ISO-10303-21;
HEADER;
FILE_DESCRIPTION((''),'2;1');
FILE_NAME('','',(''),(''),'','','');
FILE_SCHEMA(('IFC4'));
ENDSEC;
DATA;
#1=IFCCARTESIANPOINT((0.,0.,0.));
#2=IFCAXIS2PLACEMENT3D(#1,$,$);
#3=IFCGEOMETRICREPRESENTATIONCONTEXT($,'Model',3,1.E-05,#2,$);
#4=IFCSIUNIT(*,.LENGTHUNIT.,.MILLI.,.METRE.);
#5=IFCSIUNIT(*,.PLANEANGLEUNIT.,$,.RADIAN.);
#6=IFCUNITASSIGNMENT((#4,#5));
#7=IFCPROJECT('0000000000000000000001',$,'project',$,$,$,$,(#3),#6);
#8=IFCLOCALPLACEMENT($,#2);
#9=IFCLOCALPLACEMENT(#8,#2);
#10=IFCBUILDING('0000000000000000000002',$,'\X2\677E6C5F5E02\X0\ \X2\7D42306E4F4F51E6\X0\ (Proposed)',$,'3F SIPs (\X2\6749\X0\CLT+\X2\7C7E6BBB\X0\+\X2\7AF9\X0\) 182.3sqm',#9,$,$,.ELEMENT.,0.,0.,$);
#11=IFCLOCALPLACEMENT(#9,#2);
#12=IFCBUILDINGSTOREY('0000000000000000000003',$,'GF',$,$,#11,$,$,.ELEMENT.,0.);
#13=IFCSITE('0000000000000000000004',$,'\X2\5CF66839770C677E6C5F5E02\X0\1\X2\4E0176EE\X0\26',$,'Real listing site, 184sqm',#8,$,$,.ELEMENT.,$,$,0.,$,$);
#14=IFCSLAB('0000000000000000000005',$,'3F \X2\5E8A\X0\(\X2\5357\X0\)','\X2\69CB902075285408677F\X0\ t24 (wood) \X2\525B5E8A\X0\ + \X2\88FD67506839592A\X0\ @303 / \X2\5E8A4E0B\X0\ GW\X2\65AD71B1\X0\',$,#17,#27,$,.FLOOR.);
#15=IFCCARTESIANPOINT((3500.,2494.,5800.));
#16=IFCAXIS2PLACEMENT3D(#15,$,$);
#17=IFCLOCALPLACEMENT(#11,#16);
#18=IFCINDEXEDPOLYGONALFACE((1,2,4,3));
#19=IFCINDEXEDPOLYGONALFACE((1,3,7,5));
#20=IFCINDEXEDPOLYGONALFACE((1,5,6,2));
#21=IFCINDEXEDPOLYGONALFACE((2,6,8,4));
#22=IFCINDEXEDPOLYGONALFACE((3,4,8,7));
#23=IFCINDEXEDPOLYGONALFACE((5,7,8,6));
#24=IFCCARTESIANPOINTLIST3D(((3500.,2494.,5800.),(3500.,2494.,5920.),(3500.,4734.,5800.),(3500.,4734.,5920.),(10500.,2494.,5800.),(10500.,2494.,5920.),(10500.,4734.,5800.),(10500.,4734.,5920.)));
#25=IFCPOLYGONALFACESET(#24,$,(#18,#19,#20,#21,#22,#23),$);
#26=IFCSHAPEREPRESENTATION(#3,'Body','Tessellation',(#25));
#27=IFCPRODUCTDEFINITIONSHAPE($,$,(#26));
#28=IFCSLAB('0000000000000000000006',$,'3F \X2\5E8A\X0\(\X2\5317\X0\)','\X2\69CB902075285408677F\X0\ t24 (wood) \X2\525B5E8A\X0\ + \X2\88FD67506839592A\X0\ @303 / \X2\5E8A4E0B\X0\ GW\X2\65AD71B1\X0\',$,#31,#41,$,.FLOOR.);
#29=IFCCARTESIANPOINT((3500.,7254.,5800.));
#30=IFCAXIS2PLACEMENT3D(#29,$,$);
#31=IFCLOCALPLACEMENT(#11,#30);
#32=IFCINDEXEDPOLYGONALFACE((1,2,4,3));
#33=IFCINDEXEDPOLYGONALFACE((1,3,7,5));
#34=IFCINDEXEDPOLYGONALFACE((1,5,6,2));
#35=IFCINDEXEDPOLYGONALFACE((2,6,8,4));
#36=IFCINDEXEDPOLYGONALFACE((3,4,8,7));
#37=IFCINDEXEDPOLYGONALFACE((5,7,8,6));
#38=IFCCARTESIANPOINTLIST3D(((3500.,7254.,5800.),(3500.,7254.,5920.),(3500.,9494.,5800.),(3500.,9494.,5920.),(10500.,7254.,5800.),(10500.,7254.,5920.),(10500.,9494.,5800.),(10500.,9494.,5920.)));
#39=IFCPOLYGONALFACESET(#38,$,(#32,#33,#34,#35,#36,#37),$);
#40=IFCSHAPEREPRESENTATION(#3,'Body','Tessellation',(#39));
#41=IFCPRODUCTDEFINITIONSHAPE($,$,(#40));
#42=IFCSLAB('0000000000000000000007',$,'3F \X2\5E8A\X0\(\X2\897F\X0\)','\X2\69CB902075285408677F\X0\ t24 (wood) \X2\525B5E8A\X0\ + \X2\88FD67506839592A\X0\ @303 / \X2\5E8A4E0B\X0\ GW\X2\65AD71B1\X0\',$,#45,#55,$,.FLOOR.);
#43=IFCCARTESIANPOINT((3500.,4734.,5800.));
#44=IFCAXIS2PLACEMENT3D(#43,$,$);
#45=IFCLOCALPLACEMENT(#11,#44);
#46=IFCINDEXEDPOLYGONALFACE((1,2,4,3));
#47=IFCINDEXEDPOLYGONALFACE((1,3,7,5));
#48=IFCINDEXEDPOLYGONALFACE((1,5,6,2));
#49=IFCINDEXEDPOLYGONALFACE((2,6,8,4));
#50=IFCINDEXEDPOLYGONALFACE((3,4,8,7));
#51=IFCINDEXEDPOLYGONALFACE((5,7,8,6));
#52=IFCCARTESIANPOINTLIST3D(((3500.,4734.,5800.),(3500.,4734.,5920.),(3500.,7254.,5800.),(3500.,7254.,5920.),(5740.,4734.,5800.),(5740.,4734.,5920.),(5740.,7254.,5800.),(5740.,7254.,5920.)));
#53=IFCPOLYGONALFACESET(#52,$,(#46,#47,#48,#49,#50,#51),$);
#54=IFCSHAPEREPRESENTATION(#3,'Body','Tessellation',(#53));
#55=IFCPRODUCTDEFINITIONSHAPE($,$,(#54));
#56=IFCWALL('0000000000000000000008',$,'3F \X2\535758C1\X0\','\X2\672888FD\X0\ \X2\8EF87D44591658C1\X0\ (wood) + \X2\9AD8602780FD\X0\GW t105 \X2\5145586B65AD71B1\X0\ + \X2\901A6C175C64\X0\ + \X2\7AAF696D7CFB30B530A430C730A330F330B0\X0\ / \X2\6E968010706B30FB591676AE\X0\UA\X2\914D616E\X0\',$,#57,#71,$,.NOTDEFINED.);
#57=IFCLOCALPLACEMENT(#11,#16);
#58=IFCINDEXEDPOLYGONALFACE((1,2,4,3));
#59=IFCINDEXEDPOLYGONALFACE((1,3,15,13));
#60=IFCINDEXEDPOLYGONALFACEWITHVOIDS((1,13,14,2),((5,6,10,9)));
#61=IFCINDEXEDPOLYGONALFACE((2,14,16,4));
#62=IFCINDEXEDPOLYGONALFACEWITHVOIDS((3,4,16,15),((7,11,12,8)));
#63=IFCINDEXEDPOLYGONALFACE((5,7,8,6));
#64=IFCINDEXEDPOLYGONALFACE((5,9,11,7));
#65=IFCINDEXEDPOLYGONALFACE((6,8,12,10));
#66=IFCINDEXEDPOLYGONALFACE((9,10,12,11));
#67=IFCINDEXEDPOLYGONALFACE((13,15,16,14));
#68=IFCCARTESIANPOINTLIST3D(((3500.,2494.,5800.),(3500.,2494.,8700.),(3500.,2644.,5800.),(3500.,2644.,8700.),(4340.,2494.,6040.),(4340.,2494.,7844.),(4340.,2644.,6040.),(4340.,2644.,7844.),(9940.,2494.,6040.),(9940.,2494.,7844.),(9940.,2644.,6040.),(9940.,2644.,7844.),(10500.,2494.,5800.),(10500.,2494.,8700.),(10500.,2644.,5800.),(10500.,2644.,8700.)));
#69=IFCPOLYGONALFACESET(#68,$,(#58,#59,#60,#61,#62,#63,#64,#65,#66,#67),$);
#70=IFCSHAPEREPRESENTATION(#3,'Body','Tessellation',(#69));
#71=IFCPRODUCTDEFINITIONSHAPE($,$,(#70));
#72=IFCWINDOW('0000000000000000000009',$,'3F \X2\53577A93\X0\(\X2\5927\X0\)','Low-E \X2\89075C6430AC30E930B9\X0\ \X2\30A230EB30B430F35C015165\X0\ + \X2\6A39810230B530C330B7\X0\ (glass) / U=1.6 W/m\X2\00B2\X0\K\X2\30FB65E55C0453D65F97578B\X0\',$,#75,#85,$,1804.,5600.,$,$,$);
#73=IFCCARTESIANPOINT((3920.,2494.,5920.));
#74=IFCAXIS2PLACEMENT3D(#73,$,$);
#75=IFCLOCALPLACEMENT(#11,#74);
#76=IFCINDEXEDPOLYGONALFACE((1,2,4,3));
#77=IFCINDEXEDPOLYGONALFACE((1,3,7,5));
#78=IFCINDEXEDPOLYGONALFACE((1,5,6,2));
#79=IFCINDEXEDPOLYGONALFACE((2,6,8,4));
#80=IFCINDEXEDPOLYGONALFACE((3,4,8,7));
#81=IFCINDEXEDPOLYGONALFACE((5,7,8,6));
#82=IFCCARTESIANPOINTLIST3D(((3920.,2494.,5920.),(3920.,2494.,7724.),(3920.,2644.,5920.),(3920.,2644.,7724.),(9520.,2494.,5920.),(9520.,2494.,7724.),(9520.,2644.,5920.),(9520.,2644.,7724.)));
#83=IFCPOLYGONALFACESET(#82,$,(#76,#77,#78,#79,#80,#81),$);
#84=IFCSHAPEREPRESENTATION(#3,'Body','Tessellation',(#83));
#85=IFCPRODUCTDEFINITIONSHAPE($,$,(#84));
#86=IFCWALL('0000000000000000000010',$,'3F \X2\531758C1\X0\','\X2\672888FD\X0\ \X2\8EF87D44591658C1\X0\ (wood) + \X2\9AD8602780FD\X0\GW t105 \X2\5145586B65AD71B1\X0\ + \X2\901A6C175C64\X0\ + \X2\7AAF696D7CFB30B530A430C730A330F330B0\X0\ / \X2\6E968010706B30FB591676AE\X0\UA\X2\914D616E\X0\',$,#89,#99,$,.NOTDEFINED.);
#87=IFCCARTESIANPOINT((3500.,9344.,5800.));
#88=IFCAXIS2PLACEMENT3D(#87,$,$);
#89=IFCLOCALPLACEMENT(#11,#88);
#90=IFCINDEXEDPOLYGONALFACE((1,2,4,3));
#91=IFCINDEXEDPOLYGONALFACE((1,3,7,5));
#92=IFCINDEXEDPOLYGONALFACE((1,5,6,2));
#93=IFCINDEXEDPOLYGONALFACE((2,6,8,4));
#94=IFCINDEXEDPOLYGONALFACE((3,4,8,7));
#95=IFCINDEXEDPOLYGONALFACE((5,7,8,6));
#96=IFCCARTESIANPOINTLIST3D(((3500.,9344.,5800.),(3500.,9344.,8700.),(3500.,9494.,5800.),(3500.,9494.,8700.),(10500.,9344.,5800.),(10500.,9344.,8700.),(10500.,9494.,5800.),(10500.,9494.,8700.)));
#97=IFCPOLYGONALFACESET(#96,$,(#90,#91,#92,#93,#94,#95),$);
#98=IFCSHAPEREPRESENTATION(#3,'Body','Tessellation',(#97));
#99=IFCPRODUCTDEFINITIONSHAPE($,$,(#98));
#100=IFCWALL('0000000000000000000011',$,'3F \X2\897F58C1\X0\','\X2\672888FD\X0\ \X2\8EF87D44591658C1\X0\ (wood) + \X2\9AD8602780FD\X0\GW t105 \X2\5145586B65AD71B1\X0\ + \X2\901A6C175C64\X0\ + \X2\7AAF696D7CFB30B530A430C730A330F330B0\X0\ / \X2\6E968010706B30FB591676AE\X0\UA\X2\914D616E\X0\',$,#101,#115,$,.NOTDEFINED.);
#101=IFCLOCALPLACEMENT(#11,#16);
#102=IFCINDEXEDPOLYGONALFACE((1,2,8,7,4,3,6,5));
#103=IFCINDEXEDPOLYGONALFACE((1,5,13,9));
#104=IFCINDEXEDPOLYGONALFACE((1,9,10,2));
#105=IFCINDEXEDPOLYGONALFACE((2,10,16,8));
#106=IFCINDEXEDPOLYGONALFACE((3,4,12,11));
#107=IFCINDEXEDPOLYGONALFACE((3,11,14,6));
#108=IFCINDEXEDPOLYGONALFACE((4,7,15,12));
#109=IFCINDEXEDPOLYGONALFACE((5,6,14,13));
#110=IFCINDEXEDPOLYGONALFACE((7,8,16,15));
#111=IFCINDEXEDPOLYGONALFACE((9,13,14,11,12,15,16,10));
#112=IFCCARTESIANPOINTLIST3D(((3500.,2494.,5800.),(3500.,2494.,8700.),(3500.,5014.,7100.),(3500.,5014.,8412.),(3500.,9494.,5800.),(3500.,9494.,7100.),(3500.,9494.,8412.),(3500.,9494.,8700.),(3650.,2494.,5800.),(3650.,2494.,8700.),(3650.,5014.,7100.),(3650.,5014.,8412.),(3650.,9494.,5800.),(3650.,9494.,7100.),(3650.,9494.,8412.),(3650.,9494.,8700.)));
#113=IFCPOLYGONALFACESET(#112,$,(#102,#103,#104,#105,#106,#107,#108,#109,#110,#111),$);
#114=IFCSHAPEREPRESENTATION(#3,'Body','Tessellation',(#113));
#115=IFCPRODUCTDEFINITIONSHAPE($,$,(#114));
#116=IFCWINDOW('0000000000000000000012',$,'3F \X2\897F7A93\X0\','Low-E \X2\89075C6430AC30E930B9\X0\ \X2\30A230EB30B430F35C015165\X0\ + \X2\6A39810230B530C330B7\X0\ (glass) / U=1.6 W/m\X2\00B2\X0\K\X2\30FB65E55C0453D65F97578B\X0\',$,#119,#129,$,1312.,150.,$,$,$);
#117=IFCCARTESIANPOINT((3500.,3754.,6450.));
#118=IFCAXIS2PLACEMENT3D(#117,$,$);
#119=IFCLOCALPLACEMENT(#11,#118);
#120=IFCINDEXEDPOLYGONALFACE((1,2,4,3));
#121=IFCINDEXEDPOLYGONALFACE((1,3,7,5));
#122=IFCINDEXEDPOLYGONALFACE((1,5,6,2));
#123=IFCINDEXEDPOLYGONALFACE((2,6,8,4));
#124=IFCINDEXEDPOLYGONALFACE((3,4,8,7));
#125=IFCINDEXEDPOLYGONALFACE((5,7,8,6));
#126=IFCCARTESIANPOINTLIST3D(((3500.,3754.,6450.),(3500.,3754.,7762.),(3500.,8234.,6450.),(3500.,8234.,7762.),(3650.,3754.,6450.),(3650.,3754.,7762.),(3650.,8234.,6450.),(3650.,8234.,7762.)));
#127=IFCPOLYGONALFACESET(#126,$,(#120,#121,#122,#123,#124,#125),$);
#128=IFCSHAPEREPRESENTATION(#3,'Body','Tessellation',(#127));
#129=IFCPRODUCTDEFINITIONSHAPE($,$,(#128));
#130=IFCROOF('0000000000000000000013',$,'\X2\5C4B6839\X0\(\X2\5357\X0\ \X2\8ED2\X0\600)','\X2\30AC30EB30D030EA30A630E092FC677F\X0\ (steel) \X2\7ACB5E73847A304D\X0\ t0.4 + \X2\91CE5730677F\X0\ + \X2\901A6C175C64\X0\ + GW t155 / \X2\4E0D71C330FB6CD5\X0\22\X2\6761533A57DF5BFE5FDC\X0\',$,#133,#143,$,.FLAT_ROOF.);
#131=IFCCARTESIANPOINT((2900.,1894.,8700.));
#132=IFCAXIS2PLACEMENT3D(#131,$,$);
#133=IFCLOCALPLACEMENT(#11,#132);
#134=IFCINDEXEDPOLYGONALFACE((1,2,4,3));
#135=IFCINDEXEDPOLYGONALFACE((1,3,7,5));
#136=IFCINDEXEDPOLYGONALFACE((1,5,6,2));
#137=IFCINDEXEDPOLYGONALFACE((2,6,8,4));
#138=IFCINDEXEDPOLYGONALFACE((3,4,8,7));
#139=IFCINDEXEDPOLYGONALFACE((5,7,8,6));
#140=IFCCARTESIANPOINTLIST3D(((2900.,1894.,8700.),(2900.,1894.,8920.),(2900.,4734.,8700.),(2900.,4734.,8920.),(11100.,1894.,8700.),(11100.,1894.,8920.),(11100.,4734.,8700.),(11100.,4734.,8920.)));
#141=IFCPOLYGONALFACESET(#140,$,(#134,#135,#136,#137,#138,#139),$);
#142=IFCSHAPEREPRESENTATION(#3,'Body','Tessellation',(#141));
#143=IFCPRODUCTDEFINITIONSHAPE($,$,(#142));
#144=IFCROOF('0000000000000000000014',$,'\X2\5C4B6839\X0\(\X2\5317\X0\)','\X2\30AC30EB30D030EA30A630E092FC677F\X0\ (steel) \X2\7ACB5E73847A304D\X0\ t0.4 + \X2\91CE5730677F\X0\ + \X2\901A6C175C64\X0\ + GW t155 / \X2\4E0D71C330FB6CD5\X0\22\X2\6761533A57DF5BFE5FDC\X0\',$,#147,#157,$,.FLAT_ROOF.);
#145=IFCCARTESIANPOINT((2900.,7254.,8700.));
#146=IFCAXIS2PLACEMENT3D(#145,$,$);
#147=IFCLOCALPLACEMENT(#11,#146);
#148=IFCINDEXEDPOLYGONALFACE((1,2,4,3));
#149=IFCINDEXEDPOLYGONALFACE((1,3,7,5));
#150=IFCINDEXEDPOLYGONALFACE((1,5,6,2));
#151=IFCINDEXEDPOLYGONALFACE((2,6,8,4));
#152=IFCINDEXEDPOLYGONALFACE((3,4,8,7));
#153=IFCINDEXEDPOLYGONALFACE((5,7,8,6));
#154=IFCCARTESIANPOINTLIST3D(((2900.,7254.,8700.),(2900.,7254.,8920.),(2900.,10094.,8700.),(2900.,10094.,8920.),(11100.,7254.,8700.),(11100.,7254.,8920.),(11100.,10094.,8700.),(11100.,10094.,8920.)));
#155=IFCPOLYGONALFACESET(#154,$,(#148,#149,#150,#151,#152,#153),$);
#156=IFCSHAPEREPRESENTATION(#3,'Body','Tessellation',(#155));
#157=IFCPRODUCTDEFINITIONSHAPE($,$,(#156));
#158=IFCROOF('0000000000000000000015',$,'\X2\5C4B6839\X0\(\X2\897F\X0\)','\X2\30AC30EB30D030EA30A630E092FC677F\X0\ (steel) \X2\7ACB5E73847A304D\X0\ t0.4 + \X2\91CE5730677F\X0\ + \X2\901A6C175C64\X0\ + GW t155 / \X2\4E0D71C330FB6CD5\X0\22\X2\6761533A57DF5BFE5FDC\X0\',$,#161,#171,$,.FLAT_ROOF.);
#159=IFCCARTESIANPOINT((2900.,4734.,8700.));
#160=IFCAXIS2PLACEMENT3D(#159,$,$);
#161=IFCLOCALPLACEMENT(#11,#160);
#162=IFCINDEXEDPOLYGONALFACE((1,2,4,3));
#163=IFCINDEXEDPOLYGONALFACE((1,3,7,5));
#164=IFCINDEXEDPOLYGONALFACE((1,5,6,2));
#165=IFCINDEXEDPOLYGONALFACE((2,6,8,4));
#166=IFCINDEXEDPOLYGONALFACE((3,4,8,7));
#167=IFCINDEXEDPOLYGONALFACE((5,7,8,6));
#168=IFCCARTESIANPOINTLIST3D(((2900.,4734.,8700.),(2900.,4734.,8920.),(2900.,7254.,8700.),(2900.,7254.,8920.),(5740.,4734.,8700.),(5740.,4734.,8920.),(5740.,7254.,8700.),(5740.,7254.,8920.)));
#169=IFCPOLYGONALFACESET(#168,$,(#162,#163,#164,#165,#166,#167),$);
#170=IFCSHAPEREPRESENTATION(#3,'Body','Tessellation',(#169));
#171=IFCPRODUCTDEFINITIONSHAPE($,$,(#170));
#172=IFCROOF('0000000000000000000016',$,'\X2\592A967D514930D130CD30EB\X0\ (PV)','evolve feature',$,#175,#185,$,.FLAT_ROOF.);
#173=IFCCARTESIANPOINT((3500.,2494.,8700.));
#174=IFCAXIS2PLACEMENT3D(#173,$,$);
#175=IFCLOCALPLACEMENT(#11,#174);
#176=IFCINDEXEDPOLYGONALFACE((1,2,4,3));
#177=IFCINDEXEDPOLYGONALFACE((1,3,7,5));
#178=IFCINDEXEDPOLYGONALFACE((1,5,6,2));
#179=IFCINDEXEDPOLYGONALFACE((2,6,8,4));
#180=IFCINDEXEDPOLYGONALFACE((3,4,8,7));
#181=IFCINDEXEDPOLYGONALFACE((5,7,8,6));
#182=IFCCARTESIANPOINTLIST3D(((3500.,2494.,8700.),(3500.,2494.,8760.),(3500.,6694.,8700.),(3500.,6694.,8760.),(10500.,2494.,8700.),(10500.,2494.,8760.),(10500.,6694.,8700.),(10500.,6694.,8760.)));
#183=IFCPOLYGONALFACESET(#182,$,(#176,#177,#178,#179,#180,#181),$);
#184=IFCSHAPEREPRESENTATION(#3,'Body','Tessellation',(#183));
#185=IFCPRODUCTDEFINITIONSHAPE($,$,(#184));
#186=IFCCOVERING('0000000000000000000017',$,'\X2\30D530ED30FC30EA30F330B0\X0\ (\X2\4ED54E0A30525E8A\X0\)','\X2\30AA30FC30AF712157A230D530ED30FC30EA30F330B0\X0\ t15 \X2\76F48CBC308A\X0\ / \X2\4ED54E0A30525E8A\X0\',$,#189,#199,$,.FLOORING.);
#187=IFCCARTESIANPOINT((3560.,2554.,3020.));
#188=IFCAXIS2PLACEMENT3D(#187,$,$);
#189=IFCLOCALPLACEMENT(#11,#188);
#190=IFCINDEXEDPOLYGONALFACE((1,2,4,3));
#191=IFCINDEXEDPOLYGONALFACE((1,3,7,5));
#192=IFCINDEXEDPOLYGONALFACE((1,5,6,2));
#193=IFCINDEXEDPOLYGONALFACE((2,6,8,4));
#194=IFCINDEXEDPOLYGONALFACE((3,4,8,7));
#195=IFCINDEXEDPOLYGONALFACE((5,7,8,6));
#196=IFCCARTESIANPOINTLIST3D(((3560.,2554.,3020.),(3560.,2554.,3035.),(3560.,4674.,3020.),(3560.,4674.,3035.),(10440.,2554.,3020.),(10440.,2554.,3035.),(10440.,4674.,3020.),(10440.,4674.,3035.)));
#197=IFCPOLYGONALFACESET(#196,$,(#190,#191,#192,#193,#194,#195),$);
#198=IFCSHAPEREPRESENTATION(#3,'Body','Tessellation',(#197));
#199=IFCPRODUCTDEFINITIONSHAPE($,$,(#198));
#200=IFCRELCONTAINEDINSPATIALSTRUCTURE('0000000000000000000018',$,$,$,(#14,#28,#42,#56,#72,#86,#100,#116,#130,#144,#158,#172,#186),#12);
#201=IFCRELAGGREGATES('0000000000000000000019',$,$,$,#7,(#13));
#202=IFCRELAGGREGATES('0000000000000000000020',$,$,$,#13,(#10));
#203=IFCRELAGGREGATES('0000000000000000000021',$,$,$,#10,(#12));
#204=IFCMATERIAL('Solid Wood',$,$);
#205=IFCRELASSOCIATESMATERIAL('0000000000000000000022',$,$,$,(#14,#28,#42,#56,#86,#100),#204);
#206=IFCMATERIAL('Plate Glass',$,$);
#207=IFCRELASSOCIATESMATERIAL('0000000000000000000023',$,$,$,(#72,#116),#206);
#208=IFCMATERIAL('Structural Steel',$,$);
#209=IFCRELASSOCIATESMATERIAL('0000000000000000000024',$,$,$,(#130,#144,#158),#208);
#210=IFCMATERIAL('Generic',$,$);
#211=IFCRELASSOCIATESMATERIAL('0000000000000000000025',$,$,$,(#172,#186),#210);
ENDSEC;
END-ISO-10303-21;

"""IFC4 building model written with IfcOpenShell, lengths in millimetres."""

from ifc_helpers import new_model, si_unit, frame, frame_2d, origin, place, context, project, spatial, rectangle, extrude, material, element, fill, save


model = new_model("IFC4")

# Units and contexts
model_context = context("Model", 3, precision=1e-05, world=origin())
ifc_project = project(units=[si_unit("LENGTHUNIT", "METRE", prefix="MILLI"), si_unit("PLANEANGLEUNIT", "RADIAN")], contexts=[model_context])

# Site, building, storey
site_placement = place(None, origin())
site = spatial("IfcSite", under=ifc_project, at=site_placement, Name="島根県松江市1丁目26", ObjectType="Real listing site, 184sqm", CompositionType="ELEMENT", RefElevation=0.0)
building_placement = place(site_placement, origin())
building = spatial("IfcBuilding", under=site, at=building_placement, Name="松江市 終の住処 (Proposed)", ObjectType="3F SIPs (杉CLT+籾殻+竹) 182.3sqm", CompositionType="ELEMENT", ElevationOfRefHeight=0.0, ElevationOfTerrain=0.0)
storey_placement = place(building_placement, origin())
storey = spatial("IfcBuildingStorey", under=building, at=storey_placement, Name="GF", CompositionType="ELEMENT", Elevation=0.0)

# Slabs
ifc_material_1 = material(Name="Solid Wood")
slab_1_placement = place(storey_placement, frame((3500.0, 2494.0, 5800.0)))
element("IfcSlab", 1, at=slab_1_placement, inside=storey, material=ifc_material_1, Name="3F 床(南)", Description="構造用合板 t24 (wood) 剛床 + 製材根太 @303 / 床下 GW断熱", PredefinedType="FLOOR", context=model_context, shape_type="SweptSolid", body=[
    extrude(rectangle(XDim=7000.0, YDim=2240.0, at=frame_2d((3500.0, 1120.0))), frame((3500.0, 2494.0, 5800.0)), (0.0, 0.0, 1.0), 120.0),
])
slab_2_placement = place(storey_placement, frame((3500.0, 7254.0, 5800.0)))
element("IfcSlab", 2, at=slab_2_placement, inside=storey, material=ifc_material_1, Name="3F 床(北)", Description="構造用合板 t24 (wood) 剛床 + 製材根太 @303 / 床下 GW断熱", PredefinedType="FLOOR", context=model_context, shape_type="SweptSolid", body=[
    extrude(rectangle(XDim=7000.0, YDim=2240.0, at=frame_2d((3500.0, 1120.0))), frame((3500.0, 7254.0, 5800.0)), (0.0, 0.0, 1.0), 120.0),
])
slab_3_placement = place(storey_placement, frame((3500.0, 4734.0, 5800.0)))
element("IfcSlab", 3, at=slab_3_placement, inside=storey, material=ifc_material_1, Name="3F 床(西)", Description="構造用合板 t24 (wood) 剛床 + 製材根太 @303 / 床下 GW断熱", PredefinedType="FLOOR", context=model_context, shape_type="SweptSolid", body=[
    extrude(rectangle(XDim=2240.0, YDim=2520.0, at=frame_2d((1120.0, 1260.0))), frame((3500.0, 4734.0, 5800.0)), (0.0, 0.0, 1.0), 120.0),
])

# Wall, opening, window
wall_1_placement = place(storey_placement, frame((3500.0, 2494.0, 5800.0)))
wall_1 = element("IfcWall", 4, at=wall_1_placement, inside=storey, material=ifc_material_1, Name="3F 南壁", Description="木製 軸組外壁 (wood) + 高性能GW t105 充填断熱 + 通気層 + 窯業系サイディング / 準耐火・外皮UA配慮", PredefinedType="NOTDEFINED", context=model_context, shape_type="SweptSolid", body=[
    extrude(rectangle(XDim=7000.0, YDim=150.0, at=frame_2d((3500.0, 75.0))), frame((3500.0, 2494.0, 5800.0)), (0.0, 0.0, 1.0), 2900.0),
])
opening_1_placement = place(storey_placement, frame((3920.0, 2494.0, 5920.0)))
opening_1 = element("IfcOpeningElement", 5, at=opening_1_placement, cuts=wall_1, PredefinedType="NOTDEFINED", context=model_context, shape_type="SweptSolid", body=[
    extrude(rectangle(XDim=5600.0, YDim=150.0, at=frame_2d((2800.0, 75.0))), frame((3920.0, 2494.0, 5920.0)), (0.0, 0.0, 1.0), 1804.0),
])
ifc_material_2 = material(Name="Plate Glass")
window_1_placement = place(storey_placement, frame((3920.0, 2494.0, 5920.0)))
window_1 = element("IfcWindow", 6, at=window_1_placement, inside=storey, material=ifc_material_2, Name="3F 南窓(大)", Description="Low-E 複層ガラス アルゴン封入 + 樹脂サッシ (glass) / U=1.6 W/m²K・日射取得型", OverallHeight=1804.0, OverallWidth=5600.0, context=model_context, shape_type="SweptSolid", body=[
    extrude(rectangle(XDim=5600.0, YDim=150.0, at=frame_2d((2800.0, 75.0))), frame((3920.0, 2494.0, 5920.0)), (0.0, 0.0, 1.0), 1804.0),
])
fill(opening_1, window_1)

# Wall
wall_2_placement = place(storey_placement, frame((3500.0, 9344.0, 5800.0)))
element("IfcWall", 7, at=wall_2_placement, inside=storey, material=ifc_material_1, Name="3F 北壁", Description="木製 軸組外壁 (wood) + 高性能GW t105 充填断熱 + 通気層 + 窯業系サイディング / 準耐火・外皮UA配慮", PredefinedType="NOTDEFINED", context=model_context, shape_type="SweptSolid", body=[
    extrude(rectangle(XDim=7000.0, YDim=150.0, at=frame_2d((3500.0, 75.0))), frame((3500.0, 9344.0, 5800.0)), (0.0, 0.0, 1.0), 2900.0),
])

# Wall, opening, window
wall_3_placement = place(storey_placement, frame((3500.0, 2494.0, 5800.0)))
wall_3 = element("IfcWall", 8, at=wall_3_placement, inside=storey, material=ifc_material_1, Name="3F 西壁", Description="木製 軸組外壁 (wood) + 高性能GW t105 充填断熱 + 通気層 + 窯業系サイディング / 準耐火・外皮UA配慮", PredefinedType="NOTDEFINED", context=model_context, shape_type="SweptSolid", body=[
    extrude(rectangle(XDim=150.0, YDim=7000.0, at=frame_2d((75.0, 3500.0))), frame((3500.0, 2494.0, 5800.0)), (0.0, 0.0, 1.0), 2900.0),
])
opening_2_placement = place(storey_placement, frame((3500.0, 3754.0, 6450.0)))
opening_2 = element("IfcOpeningElement", 9, at=opening_2_placement, cuts=wall_3, PredefinedType="NOTDEFINED", context=model_context, shape_type="SweptSolid", body=[
    extrude(rectangle(XDim=150.0, YDim=4480.0, at=frame_2d((75.0, 2240.0))), frame((3500.0, 3754.0, 6450.0)), (0.0, 0.0, 1.0), 1312.0),
])
window_2_placement = place(storey_placement, frame((3500.0, 3754.0, 6450.0)))
window_2 = element("IfcWindow", 10, at=window_2_placement, inside=storey, material=ifc_material_2, Name="3F 西窓", Description="Low-E 複層ガラス アルゴン封入 + 樹脂サッシ (glass) / U=1.6 W/m²K・日射取得型", OverallHeight=1312.0, OverallWidth=150.0, context=model_context, shape_type="SweptSolid", body=[
    extrude(rectangle(XDim=150.0, YDim=4480.0, at=frame_2d((75.0, 2240.0))), frame((3500.0, 3754.0, 6450.0)), (0.0, 0.0, 1.0), 1312.0),
])
fill(opening_2, window_2)

# Roofs
ifc_material_3 = material(Name="Structural Steel")
roof_1_placement = place(storey_placement, frame((2900.0, 1894.0, 8700.0)))
element("IfcRoof", 11, at=roof_1_placement, inside=storey, material=ifc_material_3, Name="屋根(南 軒600)", Description="ガルバリウム鋼板 (steel) 立平葺き t0.4 + 野地板 + 通気層 + GW t155 / 不燃・法22条区域対応", PredefinedType="FLAT_ROOF", context=model_context, shape_type="SweptSolid", body=[
    extrude(rectangle(XDim=8200.0, YDim=2840.0, at=frame_2d((4100.0, 1420.0))), frame((2900.0, 1894.0, 8700.0)), (0.0, 0.0, 1.0), 220.0),
])
roof_2_placement = place(storey_placement, frame((2900.0, 7254.0, 8700.0)))
element("IfcRoof", 12, at=roof_2_placement, inside=storey, material=ifc_material_3, Name="屋根(北)", Description="ガルバリウム鋼板 (steel) 立平葺き t0.4 + 野地板 + 通気層 + GW t155 / 不燃・法22条区域対応", PredefinedType="FLAT_ROOF", context=model_context, shape_type="SweptSolid", body=[
    extrude(rectangle(XDim=8200.0, YDim=2840.0, at=frame_2d((4100.0, 1420.0))), frame((2900.0, 7254.0, 8700.0)), (0.0, 0.0, 1.0), 220.0),
])
roof_3_placement = place(storey_placement, frame((2900.0, 4734.0, 8700.0)))
element("IfcRoof", 13, at=roof_3_placement, inside=storey, material=ifc_material_3, Name="屋根(西)", Description="ガルバリウム鋼板 (steel) 立平葺き t0.4 + 野地板 + 通気層 + GW t155 / 不燃・法22条区域対応", PredefinedType="FLAT_ROOF", context=model_context, shape_type="SweptSolid", body=[
    extrude(rectangle(XDim=2840.0, YDim=2520.0, at=frame_2d((1420.0, 1260.0))), frame((2900.0, 4734.0, 8700.0)), (0.0, 0.0, 1.0), 220.0),
])
ifc_material_4 = material(Name="Generic")
roof_4_placement = place(storey_placement, frame((3500.0, 2494.0, 8700.0)))
element("IfcRoof", 14, at=roof_4_placement, inside=storey, material=ifc_material_4, Name="太陽光パネル (PV)", Description="evolve feature", PredefinedType="FLAT_ROOF", context=model_context, shape_type="SweptSolid", body=[
    extrude(rectangle(XDim=7000.0, YDim=4200.0, at=frame_2d((3500.0, 2100.0))), frame((3500.0, 2494.0, 8700.0)), (0.0, 0.0, 1.0), 60.0),
])

# Covering
covering_1_placement = place(storey_placement, frame((3560.0, 2554.0, 3020.0)))
element("IfcCovering", 15, at=covering_1_placement, inside=storey, material=ifc_material_4, Name="フローリング (仕上げ床)", Description="オーク無垢フローリング t15 直貼り / 仕上げ床", PredefinedType="FLOORING", context=model_context, shape_type="SweptSolid", body=[
    extrude(rectangle(XDim=6880.0, YDim=2120.0, at=frame_2d((3440.0, 1060.0))), frame((3560.0, 2554.0, 3020.0)), (0.0, 0.0, 1.0), 15.0),
])

save(model, "model.ifc")
